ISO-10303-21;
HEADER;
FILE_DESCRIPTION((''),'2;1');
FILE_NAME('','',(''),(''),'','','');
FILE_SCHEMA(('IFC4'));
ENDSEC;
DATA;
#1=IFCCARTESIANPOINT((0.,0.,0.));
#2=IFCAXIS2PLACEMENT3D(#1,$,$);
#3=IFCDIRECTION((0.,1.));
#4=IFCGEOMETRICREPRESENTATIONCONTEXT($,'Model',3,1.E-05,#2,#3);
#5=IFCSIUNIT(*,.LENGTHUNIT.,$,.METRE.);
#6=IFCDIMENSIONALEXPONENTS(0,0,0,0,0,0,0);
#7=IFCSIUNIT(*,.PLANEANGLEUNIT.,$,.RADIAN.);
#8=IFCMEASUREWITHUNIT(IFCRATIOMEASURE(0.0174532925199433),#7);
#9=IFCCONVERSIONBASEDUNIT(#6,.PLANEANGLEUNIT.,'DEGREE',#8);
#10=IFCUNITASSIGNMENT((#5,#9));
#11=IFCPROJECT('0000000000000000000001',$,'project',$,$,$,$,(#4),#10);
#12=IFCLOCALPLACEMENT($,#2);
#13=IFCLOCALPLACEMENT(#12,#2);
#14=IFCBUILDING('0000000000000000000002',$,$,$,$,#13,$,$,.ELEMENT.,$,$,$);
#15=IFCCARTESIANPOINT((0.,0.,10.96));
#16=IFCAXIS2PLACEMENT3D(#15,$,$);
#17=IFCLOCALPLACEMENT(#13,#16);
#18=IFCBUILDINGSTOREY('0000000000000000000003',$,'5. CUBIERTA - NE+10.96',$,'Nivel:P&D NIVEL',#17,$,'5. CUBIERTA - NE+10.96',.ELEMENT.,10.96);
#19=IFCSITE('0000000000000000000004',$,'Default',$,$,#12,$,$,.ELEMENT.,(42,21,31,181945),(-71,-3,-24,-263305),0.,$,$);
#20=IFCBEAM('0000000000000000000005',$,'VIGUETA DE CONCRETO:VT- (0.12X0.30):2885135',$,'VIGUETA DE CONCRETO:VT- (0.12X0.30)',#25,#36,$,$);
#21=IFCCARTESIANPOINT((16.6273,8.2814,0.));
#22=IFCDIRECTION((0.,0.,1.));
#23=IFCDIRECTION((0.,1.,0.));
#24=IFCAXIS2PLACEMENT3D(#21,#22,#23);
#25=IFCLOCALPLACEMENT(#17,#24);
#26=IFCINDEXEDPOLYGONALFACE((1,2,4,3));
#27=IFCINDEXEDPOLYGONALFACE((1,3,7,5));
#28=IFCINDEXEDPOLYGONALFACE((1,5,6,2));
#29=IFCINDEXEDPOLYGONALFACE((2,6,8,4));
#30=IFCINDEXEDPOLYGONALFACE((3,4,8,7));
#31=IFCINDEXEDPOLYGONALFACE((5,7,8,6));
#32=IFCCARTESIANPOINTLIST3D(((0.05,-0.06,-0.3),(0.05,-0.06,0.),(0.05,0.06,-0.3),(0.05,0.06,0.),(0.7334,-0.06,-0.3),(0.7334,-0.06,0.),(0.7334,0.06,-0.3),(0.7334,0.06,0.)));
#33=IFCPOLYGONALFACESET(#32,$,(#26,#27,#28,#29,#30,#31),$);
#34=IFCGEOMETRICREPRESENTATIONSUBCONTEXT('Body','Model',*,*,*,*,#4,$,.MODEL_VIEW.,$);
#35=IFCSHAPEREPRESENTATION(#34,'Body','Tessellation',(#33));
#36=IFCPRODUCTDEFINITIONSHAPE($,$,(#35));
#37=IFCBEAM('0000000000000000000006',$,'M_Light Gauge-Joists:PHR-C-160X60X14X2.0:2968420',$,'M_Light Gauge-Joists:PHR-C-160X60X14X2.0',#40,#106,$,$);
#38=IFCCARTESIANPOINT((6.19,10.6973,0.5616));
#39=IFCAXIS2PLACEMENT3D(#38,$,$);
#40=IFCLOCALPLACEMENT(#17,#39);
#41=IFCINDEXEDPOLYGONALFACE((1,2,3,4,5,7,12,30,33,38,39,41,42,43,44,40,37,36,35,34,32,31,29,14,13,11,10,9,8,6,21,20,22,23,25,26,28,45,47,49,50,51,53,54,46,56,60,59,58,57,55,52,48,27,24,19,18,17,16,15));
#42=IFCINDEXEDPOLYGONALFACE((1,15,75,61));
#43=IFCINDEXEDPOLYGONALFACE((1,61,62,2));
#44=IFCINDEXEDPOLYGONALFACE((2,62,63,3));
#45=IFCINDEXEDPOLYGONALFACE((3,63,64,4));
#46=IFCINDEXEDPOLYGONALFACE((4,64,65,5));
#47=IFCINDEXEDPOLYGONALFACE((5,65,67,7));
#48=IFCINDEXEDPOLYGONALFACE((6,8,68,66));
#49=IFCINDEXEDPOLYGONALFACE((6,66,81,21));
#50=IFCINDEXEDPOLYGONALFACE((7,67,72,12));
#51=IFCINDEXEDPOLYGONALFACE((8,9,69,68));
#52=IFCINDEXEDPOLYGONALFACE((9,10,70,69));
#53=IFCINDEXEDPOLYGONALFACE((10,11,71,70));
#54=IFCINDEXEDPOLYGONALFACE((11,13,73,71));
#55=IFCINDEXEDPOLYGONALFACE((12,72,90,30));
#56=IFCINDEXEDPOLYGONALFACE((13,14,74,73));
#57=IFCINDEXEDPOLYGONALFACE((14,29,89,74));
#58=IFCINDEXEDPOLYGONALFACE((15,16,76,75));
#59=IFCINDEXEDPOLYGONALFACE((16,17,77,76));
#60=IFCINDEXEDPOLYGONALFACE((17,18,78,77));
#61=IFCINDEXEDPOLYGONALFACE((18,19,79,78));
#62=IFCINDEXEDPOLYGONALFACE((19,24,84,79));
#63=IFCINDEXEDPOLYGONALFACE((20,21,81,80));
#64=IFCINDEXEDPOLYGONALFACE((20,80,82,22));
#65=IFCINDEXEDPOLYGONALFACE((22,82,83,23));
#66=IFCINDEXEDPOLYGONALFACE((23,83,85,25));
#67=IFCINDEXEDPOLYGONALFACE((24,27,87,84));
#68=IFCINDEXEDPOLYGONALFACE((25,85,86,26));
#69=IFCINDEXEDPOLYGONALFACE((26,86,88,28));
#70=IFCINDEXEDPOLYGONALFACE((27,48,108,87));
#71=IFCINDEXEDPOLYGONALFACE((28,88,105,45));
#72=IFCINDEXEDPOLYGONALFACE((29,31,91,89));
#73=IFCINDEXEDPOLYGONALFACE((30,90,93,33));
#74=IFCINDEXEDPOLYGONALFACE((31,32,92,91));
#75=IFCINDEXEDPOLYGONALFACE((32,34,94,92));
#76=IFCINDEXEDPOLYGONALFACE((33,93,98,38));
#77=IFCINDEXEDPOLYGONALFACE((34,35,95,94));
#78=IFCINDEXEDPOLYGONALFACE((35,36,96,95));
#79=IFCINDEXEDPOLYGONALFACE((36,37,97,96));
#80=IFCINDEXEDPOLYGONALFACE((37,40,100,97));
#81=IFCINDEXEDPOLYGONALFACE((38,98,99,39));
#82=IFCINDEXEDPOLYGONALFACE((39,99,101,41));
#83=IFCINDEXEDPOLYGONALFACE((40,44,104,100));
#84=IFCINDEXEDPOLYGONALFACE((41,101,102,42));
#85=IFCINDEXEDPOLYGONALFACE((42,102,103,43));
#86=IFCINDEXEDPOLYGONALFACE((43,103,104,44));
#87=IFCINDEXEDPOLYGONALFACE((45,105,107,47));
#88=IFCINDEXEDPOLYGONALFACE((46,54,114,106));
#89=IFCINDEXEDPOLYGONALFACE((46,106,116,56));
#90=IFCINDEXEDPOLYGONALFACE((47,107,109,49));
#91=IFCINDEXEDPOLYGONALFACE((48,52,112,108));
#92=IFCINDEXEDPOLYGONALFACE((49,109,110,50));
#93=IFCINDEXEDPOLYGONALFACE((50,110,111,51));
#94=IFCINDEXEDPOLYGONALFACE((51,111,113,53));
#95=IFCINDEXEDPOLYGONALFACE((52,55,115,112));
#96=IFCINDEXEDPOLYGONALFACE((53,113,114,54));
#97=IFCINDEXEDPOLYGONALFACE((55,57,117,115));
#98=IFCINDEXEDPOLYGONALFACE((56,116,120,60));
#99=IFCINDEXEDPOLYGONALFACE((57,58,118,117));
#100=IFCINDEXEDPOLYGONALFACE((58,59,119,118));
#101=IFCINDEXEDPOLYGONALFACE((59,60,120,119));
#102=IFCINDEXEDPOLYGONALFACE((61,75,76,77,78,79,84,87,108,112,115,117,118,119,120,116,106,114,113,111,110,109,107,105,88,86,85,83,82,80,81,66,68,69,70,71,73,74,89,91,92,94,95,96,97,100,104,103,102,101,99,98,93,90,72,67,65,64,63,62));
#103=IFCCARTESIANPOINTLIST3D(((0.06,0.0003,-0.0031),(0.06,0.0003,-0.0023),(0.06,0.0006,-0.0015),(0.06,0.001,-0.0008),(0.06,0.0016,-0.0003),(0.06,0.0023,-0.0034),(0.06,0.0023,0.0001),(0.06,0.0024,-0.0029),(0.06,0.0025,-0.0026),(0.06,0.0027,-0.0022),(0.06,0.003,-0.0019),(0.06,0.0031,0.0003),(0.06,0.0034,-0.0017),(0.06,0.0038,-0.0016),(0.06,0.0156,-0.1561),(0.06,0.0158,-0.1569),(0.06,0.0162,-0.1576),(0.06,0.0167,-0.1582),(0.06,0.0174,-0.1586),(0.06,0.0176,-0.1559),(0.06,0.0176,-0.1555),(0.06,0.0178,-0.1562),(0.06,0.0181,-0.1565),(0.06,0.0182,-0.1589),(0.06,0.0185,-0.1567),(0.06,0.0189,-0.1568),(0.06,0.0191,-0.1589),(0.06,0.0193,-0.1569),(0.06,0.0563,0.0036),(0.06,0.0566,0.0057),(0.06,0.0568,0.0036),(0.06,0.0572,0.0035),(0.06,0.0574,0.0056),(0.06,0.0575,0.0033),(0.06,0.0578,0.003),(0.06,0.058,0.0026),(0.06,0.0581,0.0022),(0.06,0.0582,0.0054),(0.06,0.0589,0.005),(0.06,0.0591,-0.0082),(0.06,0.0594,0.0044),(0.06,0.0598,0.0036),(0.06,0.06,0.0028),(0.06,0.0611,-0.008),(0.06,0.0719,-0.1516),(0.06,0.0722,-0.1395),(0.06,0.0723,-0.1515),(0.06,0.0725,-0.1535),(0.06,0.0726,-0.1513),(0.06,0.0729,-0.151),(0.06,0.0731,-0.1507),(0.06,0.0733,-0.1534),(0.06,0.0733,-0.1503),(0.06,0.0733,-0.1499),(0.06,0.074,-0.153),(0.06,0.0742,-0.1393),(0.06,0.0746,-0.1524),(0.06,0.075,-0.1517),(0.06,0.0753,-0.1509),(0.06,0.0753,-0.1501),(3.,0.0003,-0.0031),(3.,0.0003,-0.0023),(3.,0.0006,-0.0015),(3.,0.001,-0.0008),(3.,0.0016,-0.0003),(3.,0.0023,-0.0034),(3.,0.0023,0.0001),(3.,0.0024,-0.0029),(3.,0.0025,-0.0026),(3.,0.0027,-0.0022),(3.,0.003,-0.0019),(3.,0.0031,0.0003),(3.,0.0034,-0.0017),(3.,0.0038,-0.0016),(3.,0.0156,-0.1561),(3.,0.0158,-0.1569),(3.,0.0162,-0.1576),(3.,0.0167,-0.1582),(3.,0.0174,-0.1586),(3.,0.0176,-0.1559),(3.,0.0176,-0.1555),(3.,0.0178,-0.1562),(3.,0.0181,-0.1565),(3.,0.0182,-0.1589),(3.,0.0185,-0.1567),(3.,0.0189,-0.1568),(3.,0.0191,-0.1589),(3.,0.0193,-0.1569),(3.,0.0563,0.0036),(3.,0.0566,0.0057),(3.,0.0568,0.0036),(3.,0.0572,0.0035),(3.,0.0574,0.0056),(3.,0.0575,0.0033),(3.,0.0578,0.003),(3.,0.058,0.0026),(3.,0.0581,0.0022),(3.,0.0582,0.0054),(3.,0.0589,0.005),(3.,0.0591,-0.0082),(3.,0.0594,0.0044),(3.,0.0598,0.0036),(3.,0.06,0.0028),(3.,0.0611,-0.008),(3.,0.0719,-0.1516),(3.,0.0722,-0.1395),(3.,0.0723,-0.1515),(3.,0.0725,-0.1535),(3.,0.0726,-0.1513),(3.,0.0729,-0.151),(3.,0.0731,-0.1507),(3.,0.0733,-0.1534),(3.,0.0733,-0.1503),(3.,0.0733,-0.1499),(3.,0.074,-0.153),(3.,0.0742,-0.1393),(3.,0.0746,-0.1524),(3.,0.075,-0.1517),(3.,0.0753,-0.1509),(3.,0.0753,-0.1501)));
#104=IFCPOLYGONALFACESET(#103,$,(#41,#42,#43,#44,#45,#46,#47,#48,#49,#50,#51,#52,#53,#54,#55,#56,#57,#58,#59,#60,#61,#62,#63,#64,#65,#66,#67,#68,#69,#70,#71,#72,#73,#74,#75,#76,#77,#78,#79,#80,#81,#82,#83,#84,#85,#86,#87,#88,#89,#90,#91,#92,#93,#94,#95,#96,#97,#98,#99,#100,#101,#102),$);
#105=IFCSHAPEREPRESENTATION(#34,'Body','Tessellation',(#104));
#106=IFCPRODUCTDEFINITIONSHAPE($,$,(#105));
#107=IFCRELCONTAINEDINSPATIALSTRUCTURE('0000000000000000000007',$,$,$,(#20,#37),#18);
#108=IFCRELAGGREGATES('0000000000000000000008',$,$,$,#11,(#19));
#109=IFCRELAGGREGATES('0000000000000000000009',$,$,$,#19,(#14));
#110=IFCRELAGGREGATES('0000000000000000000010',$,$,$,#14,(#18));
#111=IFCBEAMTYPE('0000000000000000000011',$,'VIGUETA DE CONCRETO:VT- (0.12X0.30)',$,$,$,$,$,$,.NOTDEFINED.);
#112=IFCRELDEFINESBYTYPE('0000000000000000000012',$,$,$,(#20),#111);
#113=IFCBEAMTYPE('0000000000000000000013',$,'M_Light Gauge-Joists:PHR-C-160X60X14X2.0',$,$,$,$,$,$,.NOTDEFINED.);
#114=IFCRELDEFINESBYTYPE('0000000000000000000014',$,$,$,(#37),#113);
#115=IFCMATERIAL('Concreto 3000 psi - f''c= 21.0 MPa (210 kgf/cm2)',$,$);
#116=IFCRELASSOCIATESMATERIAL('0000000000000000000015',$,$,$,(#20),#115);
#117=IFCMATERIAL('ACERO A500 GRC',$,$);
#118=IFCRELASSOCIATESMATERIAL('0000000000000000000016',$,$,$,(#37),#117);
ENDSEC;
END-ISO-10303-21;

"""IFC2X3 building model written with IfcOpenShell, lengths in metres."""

from ifc_helpers import new_model, entity, si_unit, converted_unit, direction, frame, frame_2d, origin, place, context, subcontext, project, spatial, polyline, circle_curve, parameter, trimmed, segment, composite_curve, rectangle, outline, extrude, material, type_object, element, save


model = new_model("IFC2X3")

# Units and contexts
model_context = context("Model", 3, precision=1e-05, world=origin(), true_north=direction((0.0, 1.0)))
body_context = subcontext(model_context, "Body", "Model", "MODEL_VIEW")
ifc_project = project(units=[si_unit("LENGTHUNIT", "METRE"), converted_unit("PLANEANGLEUNIT", "DEGREE", entity("IfcRatioMeasure", 0.0174532925199433), si_unit("PLANEANGLEUNIT", "RADIAN"), dimensions=[0, 0, 0, 0, 0, 0, 0])], contexts=[model_context])

# Site, building, storey
site_placement = place(None, origin())
site = spatial("IfcSite", under=ifc_project, at=site_placement, Name="Default", CompositionType="ELEMENT", RefLatitude=(42, 21, 31, 181945), RefLongitude=(-71, -3, -24, -263305), RefElevation=0.0)
building_placement = place(site_placement, origin())
building = spatial("IfcBuilding", under=site, at=building_placement, CompositionType="ELEMENT")
storey_placement = place(building_placement, frame((0.0, 0.0, 10.96)))
storey = spatial("IfcBuildingStorey", under=building, at=storey_placement, Name="5. CUBIERTA - NE+10.96", ObjectType="Nivel:P&D NIVEL", LongName="5. CUBIERTA - NE+10.96", CompositionType="ELEMENT", Elevation=10.96)

# Beams
ifc_material_1 = material(Name="Concreto 3000 psi - f'c= 21.0 MPa (210 kgf/cm2)")
beam_type_1 = type_object("IfcBeamType", Name="VIGUETA DE CONCRETO:VT- (0.12X0.30)", PredefinedType="NOTDEFINED")
beam_1_placement = place(storey_placement, frame((16.6273, 8.2814, 0.0), z_axis=(0.0, 0.0, 1.0), x_axis=(0.0, 1.0, 0.0)))
element("IfcBeam", 1, at=beam_1_placement, inside=storey, type_object=beam_type_1, material=ifc_material_1, Name="VIGUETA DE CONCRETO:VT- (0.12X0.30):2885135", ObjectType="VIGUETA DE CONCRETO:VT- (0.12X0.30)", context=body_context, shape_type="SweptSolid", body=[
    extrude(rectangle(XDim=0.3, YDim=0.12, at=frame_2d((0.0, 0.0), x_axis=(1.0, 0.0))), frame((0.05, 0.0, -0.15), z_axis=(1.0, 0.0, 0.0), x_axis=(0.0, 0.0, -1.0)), (0.0, 0.0, 1.0), 0.6834),
])
ifc_material_2 = material(Name="ACERO A500 GRC")
beam_type_2 = type_object("IfcBeamType", Name="M_Light Gauge-Joists:PHR-C-160X60X14X2.0", PredefinedType="NOTDEFINED")
beam_2_placement = place(storey_placement, frame((6.19, 10.6973, 0.5616)))
element("IfcBeam", 2, at=beam_2_placement, inside=storey, type_object=beam_type_2, material=ifc_material_2, Name="M_Light Gauge-Joists:PHR-C-160X60X14X2.0:2968420", ObjectType="M_Light Gauge-Joists:PHR-C-160X60X14X2.0", context=body_context, shape_type="SweptSolid", body=[
    extrude(outline(composite_curve([segment(trimmed(circle_curve(frame_2d((-0.0764, -0.0322), x_axis=(-1.0, 0.0)), 0.0016), [parameter(0.0)], [parameter(90.0)], True, "PARAMETER"), False, "CONTINUOUS"), segment(polyline([(-0.078, -0.0322), (-0.078, 0.0206)]), True, "CONTINUOUS"), segment(trimmed(circle_curve(frame_2d((-0.0764, 0.0206), x_axis=(0.0, 1.0)), 0.0016), [parameter(0.0)], [parameter(90.0)], True, "PARAMETER"), False, "CONTINUOUS"), segment(polyline([(-0.0764, 0.0222), (-0.066, 0.0222)]), True, "CONTINUOUS"), segment(polyline([(-0.066, 0.0222), (-0.066, 0.0242)]), True, "CONTINUOUS"), segment(polyline([(-0.066, 0.0242), (-0.0768, 0.0242)]), True, "CONTINUOUS"), segment(trimmed(circle_curve(frame_2d((-0.0768, 0.021), x_axis=(-1.0, 0.0)), 0.0032), [parameter(270.0)], [parameter(0.0)], True, "PARAMETER"), True, "CONTINUOUS"), segment(polyline([(-0.08, 0.021), (-0.08, -0.0326)]), True, "CONTINUOUS"), segment(trimmed(circle_curve(frame_2d((-0.0768, -0.0326), x_axis=(0.0, -1.0)), 0.0032), [parameter(270.0)], [parameter(0.0)], True, "PARAMETER"), True, "CONTINUOUS"), segment(polyline([(-0.0768, -0.0358), (0.0768, -0.0358)]), True, "CONTINUOUS"), segment(trimmed(circle_curve(frame_2d((0.0768, -0.0326), x_axis=(1.0, 0.0)), 0.0032), [parameter(270.0)], [parameter(0.0)], True, "PARAMETER"), True, "CONTINUOUS"), segment(polyline([(0.08, -0.0326), (0.08, 0.021)]), True, "CONTINUOUS"), segment(trimmed(circle_curve(frame_2d((0.0768, 0.021), x_axis=(0.0, 1.0)), 0.0032), [parameter(270.0)], [parameter(0.0)], True, "PARAMETER"), True, "CONTINUOUS"), segment(polyline([(0.0768, 0.0242), (0.066, 0.0242)]), True, "CONTINUOUS"), segment(polyline([(0.066, 0.0242), (0.066, 0.0222)]), True, "CONTINUOUS"), segment(polyline([(0.066, 0.0222), (0.0764, 0.0222)]), True, "CONTINUOUS"), segment(trimmed(circle_curve(frame_2d((0.0764, 0.0206), x_axis=(1.0, 0.0)), 0.0016), [parameter(0.0)], [parameter(90.0)], True, "PARAMETER"), False, "CONTINUOUS"), segment(polyline([(0.078, 0.0206), (0.078, -0.0322)]), True, "CONTINUOUS"), segment(trimmed(circle_curve(frame_2d((0.0764, -0.0322), x_axis=(0.0, -1.0)), 0.0016), [parameter(0.0)], [parameter(90.0)], True, "PARAMETER"), False, "CONTINUOUS"), segment(polyline([(0.0764, -0.0338), (-0.0764, -0.0338)]), True, "CONTINUOUS")], self_intersect=False)), frame((0.06, 0.0436, -0.076), z_axis=(-1.0, 0.0, 0.0), x_axis=(0.0, -0.099504, 0.995037)), (0.0, 0.0, -1.0), 2.94),
])

save(model, "model.ifc")
